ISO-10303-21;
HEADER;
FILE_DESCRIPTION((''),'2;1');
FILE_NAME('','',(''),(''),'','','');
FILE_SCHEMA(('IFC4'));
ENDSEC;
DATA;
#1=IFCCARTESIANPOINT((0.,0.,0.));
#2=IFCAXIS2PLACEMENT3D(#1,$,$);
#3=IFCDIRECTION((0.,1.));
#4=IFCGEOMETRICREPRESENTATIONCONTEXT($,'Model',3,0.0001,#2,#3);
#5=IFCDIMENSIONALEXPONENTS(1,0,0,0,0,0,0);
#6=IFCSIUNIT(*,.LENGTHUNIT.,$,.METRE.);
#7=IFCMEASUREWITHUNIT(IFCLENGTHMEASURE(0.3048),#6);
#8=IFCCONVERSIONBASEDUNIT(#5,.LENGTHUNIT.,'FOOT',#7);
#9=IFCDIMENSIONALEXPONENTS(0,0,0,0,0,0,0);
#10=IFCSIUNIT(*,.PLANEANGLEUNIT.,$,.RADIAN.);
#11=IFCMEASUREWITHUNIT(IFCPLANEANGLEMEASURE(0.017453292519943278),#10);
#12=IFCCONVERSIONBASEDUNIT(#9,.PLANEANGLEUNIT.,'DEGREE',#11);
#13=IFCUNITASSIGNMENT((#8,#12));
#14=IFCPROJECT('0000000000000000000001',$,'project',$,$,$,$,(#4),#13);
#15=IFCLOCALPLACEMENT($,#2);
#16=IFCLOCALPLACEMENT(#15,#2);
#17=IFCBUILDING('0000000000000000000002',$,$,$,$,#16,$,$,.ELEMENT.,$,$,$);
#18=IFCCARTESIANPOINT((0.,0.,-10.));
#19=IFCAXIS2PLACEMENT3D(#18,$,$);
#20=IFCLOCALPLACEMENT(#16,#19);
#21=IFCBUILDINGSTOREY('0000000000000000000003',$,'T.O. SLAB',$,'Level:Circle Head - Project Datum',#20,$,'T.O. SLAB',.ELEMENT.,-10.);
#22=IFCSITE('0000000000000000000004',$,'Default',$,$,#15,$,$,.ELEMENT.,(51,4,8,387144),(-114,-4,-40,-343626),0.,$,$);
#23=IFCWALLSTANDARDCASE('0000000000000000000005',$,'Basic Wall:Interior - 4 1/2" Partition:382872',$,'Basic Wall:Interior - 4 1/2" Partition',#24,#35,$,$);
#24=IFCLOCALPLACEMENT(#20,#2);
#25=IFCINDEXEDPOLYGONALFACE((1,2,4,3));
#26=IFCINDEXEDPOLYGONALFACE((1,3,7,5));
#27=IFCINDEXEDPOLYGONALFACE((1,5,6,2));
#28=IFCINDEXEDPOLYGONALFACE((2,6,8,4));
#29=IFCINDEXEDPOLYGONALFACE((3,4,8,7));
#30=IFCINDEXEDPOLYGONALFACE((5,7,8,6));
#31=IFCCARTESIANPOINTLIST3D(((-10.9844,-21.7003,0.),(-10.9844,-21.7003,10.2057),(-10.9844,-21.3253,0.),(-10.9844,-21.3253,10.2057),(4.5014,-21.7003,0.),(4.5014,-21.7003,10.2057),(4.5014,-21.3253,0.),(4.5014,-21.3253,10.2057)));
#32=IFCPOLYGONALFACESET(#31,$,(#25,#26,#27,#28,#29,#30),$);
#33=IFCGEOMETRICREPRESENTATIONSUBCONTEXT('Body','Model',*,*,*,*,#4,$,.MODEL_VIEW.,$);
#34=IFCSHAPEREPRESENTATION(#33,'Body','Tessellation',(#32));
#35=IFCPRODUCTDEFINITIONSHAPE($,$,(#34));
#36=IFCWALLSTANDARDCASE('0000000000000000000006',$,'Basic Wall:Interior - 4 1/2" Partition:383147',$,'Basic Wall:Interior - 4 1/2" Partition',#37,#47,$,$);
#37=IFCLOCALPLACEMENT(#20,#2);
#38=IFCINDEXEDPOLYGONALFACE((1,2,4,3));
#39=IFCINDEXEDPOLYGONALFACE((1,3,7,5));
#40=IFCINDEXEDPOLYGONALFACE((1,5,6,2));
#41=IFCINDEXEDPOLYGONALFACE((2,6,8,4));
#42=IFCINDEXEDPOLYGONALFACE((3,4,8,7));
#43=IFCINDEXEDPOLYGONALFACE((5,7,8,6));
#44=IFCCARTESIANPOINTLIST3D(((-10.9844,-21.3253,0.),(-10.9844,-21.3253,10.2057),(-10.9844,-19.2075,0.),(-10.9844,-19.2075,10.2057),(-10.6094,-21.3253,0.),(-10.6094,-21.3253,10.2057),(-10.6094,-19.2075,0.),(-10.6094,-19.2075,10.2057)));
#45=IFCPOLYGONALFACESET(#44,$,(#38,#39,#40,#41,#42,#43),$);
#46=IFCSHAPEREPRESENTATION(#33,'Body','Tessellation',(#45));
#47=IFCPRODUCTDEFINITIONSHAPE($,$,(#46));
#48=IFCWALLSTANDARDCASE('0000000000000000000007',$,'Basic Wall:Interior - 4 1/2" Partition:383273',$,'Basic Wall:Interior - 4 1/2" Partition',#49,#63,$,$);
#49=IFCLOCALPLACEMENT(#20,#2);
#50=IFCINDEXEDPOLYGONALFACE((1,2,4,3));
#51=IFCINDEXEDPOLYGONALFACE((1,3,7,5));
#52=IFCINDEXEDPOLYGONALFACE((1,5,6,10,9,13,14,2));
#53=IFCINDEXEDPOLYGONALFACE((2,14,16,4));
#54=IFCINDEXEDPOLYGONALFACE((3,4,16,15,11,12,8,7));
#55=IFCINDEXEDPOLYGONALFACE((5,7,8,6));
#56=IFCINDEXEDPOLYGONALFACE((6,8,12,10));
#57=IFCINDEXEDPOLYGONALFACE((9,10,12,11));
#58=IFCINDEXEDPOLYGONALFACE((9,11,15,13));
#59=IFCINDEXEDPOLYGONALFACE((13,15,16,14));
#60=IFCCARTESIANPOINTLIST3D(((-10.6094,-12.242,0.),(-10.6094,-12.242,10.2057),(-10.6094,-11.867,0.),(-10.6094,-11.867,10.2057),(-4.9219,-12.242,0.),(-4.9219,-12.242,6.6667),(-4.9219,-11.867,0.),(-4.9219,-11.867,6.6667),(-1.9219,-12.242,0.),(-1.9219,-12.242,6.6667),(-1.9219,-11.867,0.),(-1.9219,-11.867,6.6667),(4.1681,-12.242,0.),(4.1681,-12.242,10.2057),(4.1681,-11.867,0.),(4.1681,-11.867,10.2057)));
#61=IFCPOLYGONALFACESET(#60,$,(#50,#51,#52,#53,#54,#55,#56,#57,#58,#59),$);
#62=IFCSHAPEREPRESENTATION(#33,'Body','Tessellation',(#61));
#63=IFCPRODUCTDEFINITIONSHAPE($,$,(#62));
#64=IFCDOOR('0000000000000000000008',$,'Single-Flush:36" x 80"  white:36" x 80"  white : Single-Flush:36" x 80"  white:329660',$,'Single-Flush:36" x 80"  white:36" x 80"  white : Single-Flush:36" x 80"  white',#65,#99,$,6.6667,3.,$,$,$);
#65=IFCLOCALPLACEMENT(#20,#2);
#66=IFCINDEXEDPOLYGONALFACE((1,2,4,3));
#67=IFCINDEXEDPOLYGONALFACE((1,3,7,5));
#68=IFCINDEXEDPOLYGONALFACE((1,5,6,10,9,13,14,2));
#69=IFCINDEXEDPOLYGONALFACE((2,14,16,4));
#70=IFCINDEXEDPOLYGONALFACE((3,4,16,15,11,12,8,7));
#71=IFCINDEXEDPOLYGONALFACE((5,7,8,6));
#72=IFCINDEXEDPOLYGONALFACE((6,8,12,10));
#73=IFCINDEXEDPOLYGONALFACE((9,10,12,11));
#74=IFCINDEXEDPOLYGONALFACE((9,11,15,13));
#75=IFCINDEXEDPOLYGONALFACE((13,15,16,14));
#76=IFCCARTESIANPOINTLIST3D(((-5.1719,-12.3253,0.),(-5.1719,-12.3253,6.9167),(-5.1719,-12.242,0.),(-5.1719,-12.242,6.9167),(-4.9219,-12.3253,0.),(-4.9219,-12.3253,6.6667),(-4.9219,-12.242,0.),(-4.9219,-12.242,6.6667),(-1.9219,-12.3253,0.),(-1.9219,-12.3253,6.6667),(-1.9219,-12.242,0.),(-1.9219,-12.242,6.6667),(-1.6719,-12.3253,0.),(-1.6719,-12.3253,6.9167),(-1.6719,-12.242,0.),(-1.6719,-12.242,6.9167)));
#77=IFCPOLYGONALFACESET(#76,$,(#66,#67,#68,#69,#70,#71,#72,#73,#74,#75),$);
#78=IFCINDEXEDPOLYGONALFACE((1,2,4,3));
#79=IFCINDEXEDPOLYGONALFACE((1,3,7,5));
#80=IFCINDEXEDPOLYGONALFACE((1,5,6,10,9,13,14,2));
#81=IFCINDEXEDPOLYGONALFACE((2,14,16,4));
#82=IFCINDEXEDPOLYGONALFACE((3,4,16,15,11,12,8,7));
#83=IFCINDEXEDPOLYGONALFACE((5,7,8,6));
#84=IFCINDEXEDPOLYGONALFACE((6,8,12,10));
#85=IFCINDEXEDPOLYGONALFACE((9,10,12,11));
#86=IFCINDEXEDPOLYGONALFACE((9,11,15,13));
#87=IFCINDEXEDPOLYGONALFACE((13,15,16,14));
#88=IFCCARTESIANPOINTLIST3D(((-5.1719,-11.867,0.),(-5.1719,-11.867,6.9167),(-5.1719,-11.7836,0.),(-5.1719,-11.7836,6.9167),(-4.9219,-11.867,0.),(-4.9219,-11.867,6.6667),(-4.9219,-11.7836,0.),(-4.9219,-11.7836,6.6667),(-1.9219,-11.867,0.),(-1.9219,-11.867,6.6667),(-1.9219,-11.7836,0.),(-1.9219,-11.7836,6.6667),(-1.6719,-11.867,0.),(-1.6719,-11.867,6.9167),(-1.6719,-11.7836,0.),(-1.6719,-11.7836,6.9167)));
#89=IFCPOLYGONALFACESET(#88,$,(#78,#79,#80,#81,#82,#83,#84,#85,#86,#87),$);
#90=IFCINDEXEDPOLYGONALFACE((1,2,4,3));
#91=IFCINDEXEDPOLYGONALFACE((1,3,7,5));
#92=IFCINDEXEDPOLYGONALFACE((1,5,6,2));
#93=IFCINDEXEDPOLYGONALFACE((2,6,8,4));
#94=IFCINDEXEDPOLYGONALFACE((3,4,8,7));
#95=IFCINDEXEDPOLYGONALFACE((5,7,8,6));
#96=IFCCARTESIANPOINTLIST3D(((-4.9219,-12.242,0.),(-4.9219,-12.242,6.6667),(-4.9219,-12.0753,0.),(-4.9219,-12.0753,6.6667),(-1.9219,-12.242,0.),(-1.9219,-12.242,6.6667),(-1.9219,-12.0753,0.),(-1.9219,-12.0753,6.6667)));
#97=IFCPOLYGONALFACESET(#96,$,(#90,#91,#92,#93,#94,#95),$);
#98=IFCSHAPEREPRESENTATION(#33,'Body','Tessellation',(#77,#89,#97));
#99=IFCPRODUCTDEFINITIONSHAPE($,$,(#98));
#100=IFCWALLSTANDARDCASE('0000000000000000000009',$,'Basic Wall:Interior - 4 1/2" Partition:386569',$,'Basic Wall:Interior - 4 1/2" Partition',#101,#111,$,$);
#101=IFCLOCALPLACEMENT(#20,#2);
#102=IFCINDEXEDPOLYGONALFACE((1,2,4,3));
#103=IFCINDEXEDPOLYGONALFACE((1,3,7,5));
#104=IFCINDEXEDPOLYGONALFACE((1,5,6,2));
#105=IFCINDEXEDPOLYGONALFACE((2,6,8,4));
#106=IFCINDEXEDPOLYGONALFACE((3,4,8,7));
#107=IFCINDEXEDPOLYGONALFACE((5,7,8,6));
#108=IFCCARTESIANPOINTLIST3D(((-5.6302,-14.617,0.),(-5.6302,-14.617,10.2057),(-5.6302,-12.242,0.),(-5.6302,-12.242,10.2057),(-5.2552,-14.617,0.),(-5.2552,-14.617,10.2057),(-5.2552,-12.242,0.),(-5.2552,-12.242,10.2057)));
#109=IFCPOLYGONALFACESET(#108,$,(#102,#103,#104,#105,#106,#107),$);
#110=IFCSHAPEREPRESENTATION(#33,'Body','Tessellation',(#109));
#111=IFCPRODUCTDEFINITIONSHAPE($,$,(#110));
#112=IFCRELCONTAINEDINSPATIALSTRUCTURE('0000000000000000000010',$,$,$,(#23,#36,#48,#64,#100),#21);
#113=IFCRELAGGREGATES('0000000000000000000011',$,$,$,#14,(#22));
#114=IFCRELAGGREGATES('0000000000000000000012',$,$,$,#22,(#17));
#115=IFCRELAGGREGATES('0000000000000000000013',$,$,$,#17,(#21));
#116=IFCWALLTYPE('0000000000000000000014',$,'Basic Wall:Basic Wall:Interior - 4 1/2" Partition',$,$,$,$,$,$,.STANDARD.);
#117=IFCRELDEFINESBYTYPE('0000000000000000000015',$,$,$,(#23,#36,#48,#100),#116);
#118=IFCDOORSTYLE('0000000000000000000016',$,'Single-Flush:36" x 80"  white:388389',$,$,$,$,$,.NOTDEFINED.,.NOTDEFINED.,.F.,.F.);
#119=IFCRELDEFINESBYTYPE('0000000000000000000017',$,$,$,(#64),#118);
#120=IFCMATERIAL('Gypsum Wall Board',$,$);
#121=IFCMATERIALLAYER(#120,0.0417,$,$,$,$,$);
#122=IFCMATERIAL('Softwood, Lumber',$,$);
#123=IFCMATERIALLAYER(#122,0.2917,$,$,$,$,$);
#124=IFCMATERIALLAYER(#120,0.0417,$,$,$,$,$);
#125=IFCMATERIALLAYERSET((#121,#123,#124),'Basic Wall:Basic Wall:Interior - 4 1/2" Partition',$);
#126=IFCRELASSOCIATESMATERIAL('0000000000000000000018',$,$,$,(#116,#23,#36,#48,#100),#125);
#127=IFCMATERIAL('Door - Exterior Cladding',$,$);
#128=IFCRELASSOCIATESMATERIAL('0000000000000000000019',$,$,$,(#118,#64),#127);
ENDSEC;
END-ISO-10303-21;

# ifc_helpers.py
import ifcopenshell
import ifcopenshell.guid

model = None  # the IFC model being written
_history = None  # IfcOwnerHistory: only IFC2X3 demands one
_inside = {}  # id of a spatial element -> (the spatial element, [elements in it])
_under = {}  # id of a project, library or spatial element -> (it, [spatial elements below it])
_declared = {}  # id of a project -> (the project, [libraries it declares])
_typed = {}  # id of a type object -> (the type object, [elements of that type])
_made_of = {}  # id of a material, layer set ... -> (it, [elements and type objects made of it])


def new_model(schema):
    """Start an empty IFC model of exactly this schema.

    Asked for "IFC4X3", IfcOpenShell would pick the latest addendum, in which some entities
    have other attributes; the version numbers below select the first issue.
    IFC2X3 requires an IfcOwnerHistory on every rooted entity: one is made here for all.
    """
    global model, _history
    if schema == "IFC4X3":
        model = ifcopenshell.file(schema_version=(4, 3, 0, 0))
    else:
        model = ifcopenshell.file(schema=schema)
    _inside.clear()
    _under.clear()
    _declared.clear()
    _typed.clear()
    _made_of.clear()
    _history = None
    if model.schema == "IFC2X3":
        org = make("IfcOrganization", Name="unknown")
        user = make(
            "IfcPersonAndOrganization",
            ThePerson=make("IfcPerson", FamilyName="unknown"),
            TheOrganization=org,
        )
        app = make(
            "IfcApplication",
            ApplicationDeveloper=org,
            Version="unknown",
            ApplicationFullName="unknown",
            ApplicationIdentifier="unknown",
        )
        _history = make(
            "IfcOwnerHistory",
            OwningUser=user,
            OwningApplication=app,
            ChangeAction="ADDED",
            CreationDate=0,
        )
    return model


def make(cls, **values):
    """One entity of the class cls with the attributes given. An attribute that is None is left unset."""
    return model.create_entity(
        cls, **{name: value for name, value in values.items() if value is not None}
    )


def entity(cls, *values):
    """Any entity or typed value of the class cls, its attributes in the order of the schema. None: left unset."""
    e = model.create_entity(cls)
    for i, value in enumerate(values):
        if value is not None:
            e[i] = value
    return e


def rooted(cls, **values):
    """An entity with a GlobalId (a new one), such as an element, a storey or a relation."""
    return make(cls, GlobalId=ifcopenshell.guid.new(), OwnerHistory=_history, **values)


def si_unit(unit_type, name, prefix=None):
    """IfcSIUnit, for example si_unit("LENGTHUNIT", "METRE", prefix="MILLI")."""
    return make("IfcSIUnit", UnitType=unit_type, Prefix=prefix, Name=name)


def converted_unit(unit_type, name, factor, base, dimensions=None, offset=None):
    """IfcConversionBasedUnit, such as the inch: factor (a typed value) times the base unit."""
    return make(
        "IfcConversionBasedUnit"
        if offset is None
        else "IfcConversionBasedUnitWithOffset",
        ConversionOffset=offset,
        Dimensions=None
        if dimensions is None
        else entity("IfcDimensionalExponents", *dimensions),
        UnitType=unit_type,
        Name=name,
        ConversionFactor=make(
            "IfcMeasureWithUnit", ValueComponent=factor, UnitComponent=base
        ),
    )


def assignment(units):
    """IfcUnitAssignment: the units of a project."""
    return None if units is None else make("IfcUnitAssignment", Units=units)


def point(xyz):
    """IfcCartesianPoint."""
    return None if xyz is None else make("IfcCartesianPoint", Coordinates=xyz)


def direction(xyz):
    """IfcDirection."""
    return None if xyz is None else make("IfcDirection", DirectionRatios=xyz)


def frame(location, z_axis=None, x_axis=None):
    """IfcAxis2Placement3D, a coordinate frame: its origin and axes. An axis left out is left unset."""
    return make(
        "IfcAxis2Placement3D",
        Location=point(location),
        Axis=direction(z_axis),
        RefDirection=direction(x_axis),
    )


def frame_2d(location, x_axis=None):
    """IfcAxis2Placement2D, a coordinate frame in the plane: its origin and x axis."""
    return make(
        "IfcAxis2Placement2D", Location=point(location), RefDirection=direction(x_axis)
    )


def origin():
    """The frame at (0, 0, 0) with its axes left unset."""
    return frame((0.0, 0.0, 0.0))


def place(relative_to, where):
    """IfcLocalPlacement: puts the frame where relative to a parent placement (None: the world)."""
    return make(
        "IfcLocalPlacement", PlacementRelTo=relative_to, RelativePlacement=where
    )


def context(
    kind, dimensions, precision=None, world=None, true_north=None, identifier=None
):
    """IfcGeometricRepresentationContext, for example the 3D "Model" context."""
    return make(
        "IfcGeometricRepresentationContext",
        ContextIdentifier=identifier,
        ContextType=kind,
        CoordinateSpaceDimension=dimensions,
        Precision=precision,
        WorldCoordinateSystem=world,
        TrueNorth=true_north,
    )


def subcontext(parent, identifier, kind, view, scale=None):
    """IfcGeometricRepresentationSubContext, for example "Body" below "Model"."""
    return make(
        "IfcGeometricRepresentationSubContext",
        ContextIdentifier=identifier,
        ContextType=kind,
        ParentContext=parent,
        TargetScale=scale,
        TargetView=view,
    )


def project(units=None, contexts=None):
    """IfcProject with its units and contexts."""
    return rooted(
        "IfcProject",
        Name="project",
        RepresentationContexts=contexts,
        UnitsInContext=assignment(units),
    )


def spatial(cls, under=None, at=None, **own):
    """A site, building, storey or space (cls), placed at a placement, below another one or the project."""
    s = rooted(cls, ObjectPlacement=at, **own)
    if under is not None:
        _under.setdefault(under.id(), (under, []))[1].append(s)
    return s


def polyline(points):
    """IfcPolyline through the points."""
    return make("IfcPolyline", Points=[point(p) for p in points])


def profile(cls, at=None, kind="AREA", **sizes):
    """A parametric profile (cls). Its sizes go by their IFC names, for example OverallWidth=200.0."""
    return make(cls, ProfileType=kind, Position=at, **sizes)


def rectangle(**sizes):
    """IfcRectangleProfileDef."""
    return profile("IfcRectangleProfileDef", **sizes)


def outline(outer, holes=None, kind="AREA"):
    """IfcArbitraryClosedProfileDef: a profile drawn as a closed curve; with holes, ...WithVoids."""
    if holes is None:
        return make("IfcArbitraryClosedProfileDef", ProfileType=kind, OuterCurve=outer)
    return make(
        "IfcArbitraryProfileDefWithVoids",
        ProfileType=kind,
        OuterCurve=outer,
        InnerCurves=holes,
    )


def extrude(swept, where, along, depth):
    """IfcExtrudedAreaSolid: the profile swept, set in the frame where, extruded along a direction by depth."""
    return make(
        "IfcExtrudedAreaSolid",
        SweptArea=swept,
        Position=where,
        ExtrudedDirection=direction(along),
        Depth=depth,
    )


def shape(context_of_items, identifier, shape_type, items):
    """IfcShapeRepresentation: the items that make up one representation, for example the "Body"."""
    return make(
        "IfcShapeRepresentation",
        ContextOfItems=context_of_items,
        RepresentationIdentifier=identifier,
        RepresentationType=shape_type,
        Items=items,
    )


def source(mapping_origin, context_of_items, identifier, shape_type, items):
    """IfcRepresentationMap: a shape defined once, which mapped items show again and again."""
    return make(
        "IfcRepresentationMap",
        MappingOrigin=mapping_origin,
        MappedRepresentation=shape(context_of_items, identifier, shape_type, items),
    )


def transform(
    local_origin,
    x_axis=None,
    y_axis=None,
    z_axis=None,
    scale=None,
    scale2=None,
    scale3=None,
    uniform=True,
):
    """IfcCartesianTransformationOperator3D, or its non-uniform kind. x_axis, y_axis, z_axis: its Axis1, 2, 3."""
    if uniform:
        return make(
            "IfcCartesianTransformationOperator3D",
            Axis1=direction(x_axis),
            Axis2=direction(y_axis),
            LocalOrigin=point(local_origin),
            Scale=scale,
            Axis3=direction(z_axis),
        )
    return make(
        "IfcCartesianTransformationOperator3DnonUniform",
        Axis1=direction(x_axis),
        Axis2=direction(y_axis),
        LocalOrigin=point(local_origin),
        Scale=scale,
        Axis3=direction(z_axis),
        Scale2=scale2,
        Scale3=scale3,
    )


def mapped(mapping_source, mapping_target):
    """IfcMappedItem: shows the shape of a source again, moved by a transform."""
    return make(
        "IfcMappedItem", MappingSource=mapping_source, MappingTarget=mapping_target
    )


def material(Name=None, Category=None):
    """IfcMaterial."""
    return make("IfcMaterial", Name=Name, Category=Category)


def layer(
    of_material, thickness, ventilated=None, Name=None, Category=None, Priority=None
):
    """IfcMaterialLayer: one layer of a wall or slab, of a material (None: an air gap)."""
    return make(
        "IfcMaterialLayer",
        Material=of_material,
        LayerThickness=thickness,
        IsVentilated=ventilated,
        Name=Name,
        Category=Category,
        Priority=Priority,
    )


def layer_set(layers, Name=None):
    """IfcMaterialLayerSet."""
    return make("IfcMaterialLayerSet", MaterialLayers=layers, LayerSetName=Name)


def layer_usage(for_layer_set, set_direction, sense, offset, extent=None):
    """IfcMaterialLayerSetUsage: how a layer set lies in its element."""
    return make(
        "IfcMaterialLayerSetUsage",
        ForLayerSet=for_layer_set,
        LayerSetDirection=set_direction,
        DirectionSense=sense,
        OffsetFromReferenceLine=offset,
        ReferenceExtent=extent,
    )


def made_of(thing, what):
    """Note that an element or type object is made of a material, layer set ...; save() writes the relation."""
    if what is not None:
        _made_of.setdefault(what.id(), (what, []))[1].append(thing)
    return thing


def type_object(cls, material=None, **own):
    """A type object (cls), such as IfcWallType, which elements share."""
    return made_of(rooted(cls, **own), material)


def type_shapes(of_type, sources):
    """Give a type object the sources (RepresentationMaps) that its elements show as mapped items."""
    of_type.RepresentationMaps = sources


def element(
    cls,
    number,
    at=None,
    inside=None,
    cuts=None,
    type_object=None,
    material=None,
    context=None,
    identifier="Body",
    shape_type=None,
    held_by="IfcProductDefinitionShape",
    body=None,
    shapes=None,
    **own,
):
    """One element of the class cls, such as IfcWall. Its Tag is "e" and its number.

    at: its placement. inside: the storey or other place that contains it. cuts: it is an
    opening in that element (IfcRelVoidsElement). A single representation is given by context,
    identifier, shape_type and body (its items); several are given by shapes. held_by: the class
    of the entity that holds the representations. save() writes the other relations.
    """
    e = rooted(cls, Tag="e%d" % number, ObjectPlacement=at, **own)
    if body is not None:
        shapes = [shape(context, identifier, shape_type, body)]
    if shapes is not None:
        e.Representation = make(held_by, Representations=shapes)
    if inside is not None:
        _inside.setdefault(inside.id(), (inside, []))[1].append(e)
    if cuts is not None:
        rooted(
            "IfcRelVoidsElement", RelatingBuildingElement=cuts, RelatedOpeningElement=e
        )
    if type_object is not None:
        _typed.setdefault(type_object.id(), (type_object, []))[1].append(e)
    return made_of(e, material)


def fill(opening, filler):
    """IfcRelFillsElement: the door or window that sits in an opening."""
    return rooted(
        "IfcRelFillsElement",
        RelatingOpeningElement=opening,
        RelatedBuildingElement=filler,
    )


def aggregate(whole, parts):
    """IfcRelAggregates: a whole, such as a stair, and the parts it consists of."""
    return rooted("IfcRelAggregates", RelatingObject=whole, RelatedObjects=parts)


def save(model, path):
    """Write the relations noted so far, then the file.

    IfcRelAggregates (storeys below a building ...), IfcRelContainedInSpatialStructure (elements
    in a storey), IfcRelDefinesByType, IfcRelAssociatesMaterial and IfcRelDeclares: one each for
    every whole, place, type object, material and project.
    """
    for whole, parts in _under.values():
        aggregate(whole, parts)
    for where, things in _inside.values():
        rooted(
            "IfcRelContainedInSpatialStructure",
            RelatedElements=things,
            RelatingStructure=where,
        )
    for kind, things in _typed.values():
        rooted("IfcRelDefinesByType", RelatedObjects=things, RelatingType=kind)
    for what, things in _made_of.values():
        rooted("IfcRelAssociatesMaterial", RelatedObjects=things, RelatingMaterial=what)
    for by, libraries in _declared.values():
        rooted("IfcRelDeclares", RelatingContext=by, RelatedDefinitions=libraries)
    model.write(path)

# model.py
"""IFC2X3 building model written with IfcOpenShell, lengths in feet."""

from ifc_helpers import new_model, entity, si_unit, converted_unit, direction, frame, frame_2d, origin, place, context, subcontext, project, spatial, polyline, rectangle, outline, extrude, source, transform, mapped, material, layer, layer_set, layer_usage, type_object, type_shapes, element, fill, save


model = new_model("IFC2X3")

# Units and contexts
model_context = context("Model", 3, precision=0.0001, world=origin(), true_north=direction((0.0, 1.0)))
body_context = subcontext(model_context, "Body", "Model", "MODEL_VIEW")
ifc_project = project(units=[converted_unit("LENGTHUNIT", "FOOT", entity("IfcLengthMeasure", 0.3048), si_unit("LENGTHUNIT", "METRE"), dimensions=[1, 0, 0, 0, 0, 0, 0]), converted_unit("PLANEANGLEUNIT", "DEGREE", entity("IfcPlaneAngleMeasure", 0.017453292519943278), si_unit("PLANEANGLEUNIT", "RADIAN"), dimensions=[0, 0, 0, 0, 0, 0, 0])], contexts=[model_context])

# Site, building, storey
site_placement = place(None, origin())
site = spatial("IfcSite", under=ifc_project, at=site_placement, Name="Default", CompositionType="ELEMENT", RefLatitude=(51, 4, 8, 387144), RefLongitude=(-114, -4, -40, -343626), RefElevation=0.0)
building_placement = place(site_placement, origin())
building = spatial("IfcBuilding", under=site, at=building_placement, CompositionType="ELEMENT")
storey_placement = place(building_placement, frame((0.0, 0.0, -10.0)))
storey = spatial("IfcBuildingStorey", under=building, at=storey_placement, Name="T.O. SLAB", ObjectType="Level:Circle Head - Project Datum", LongName="T.O. SLAB", CompositionType="ELEMENT", Elevation=-10.0)

# Walls
ifc_material_1 = material(Name="Gypsum Wall Board")
ifc_layer_1 = layer(ifc_material_1, 0.0417)
ifc_material_2 = material(Name="Softwood, Lumber")
ifc_layer_2 = layer(ifc_material_2, 0.2917)
ifc_layer_3 = layer(ifc_material_1, 0.0417)
ifc_layer_set_1 = layer_set([ifc_layer_1, ifc_layer_2, ifc_layer_3], Name="Basic Wall:Basic Wall:Interior - 4 1/2\" Partition")
ifc_layer_usage_1 = layer_usage(ifc_layer_set_1, "AXIS2", "NEGATIVE", 0.1875)
wall_type_1 = type_object("IfcWallType", Name="Basic Wall:Basic Wall:Interior - 4 1/2\" Partition", PredefinedType="STANDARD", material=ifc_layer_set_1)
wall_1_placement = place(storey_placement, frame((4.5014, -21.5128, 0.0), z_axis=(0.0, 0.0, 1.0), x_axis=(-1.0, 0.0, 0.0)))
element("IfcWallStandardCase", 1, at=wall_1_placement, inside=storey, type_object=wall_type_1, material=ifc_layer_usage_1, Name="Basic Wall:Interior - 4 1/2\" Partition:382872", ObjectType="Basic Wall:Interior - 4 1/2\" Partition", context=body_context, shape_type="SweptSolid", body=[
    extrude(rectangle(XDim=15.4858, YDim=0.375, at=frame_2d((7.7429, 0.0), x_axis=(-1.0, 0.0))), origin(), (0.0, 0.0, 1.0), 10.2057),
])
ifc_layer_usage_2 = layer_usage(ifc_layer_set_1, "AXIS2", "NEGATIVE", 0.1875)
wall_2_placement = place(storey_placement, frame((-10.7969, -21.3253, 0.0), z_axis=(0.0, 0.0, 1.0), x_axis=(0.0, 1.0, 0.0)))
element("IfcWallStandardCase", 2, at=wall_2_placement, inside=storey, type_object=wall_type_1, material=ifc_layer_usage_2, Name="Basic Wall:Interior - 4 1/2\" Partition:383147", ObjectType="Basic Wall:Interior - 4 1/2\" Partition", context=body_context, shape_type="SweptSolid", body=[
    extrude(rectangle(XDim=2.1178, YDim=0.375, at=frame_2d((1.0589, 0.0), x_axis=(-1.0, 0.0))), origin(), (0.0, 0.0, 1.0), 10.2057),
])

# Wall, opening, door
ifc_layer_usage_3 = layer_usage(ifc_layer_set_1, "AXIS2", "NEGATIVE", 0.1875)
wall_3_placement = place(storey_placement, frame((4.1681, -12.0545, 0.0), z_axis=(0.0, 0.0, 1.0), x_axis=(-1.0, 0.0, 0.0)))
wall_3 = element("IfcWallStandardCase", 3, at=wall_3_placement, inside=storey, type_object=wall_type_1, material=ifc_layer_usage_3, Name="Basic Wall:Interior - 4 1/2\" Partition:383273", ObjectType="Basic Wall:Interior - 4 1/2\" Partition", context=body_context, shape_type="SweptSolid", body=[
    extrude(rectangle(XDim=14.7775, YDim=0.375, at=frame_2d((7.3887, 0.0), x_axis=(1.0, 0.0))), origin(), (0.0, 0.0, 1.0), 10.2057),
])
opening_1_placement = place(wall_3_placement, frame((4.1681, -12.0545, 0.0), z_axis=(0.0, 0.0, 1.0), x_axis=(-1.0, 0.0, 0.0)))
opening_1 = element("IfcOpeningElement", 4, at=opening_1_placement, cuts=wall_3, ObjectType="Opening", context=body_context, shape_type="SweptSolid", body=[
    extrude(rectangle(XDim=6.6667, YDim=3.0, at=frame_2d((0.0, 0.0), x_axis=(1.0, 0.0))), frame((-3.4219, -11.8632, 3.3333), z_axis=(0.0, -1.0, 0.0), x_axis=(0.0, 0.0, -1.0)), (0.0, 0.0, 1.0), 0.3825),
])
ifc_material_3 = material(Name="Door - Exterior Cladding")
door_style_1 = type_object("IfcDoorStyle", Name="Single-Flush:36\" x 80\"  white:388389", ConstructionType="NOTDEFINED", OperationType="NOTDEFINED", ParameterTakesPrecedence=False, Sizeable=False, material=ifc_material_3)
shared_shape_1 = source(origin(), body_context, "Body", "SweptSolid", [
    extrude(outline(polyline([(-3.5208, -1.75), (3.3958, -1.75), (3.3958, -1.5), (-3.2708, -1.5), (-3.2708, 1.5), (3.3958, 1.5), (3.3958, 1.75), (-3.5208, 1.75), (-3.5208, -1.75)])), frame((1.5, -0.0038, 3.3958), z_axis=(0.0, 1.0, 0.0), x_axis=(0.0, 0.0, -1.0)), (0.0, 0.0, 1.0), 0.0833),
    extrude(outline(polyline([(-1.75, -3.3958), (-1.5, -3.3958), (-1.5, 3.2708), (1.5, 3.2708), (1.5, -3.3958), (1.75, -3.3958), (1.75, 3.5208), (-1.75, 3.5208), (-1.75, -3.3958)])), frame((1.5, -0.4621, 3.3958), z_axis=(0.0, 1.0, 0.0), x_axis=(-1.0, 0.0, 0.0)), (0.0, 0.0, 1.0), 0.0833),
    extrude(rectangle(XDim=3.0, YDim=0.1667, at=frame_2d((0.0, 0.0), x_axis=(1.0, 0.0))), frame((1.5, -0.0871, 0.0), z_axis=(0.0, 0.0, 1.0), x_axis=(-1.0, 0.0, 0.0)), (0.0, 0.0, 1.0), 6.6667),
])
type_shapes(door_style_1, [shared_shape_1])
door_1_placement = place(opening_1_placement, frame((-1.9219, -12.2457, 0.0), z_axis=(0.0, 0.0, 1.0), x_axis=(-1.0, 0.0, 0.0)))
door_1 = element("IfcDoor", 5, at=door_1_placement, inside=storey, type_object=door_style_1, material=ifc_material_3, Name="Single-Flush:36\" x 80\"  white:36\" x 80\"  white : Single-Flush:36\" x 80\"  white:329660", ObjectType="Single-Flush:36\" x 80\"  white:36\" x 80\"  white : Single-Flush:36\" x 80\"  white", OverallHeight=6.6667, OverallWidth=3.0, context=body_context, shape_type="MappedRepresentation", body=[
    mapped(shared_shape_1, transform((0.0, 0.0, 0.0), scale=1.0)),
])
fill(opening_1, door_1)

# Wall
ifc_layer_usage_4 = layer_usage(ifc_layer_set_1, "AXIS2", "NEGATIVE", 0.1875)
wall_4_placement = place(storey_placement, frame((-5.4427, -12.242, 0.0), z_axis=(0.0, 0.0, 1.0), x_axis=(0.0, -1.0, 0.0)))
element("IfcWallStandardCase", 6, at=wall_4_placement, inside=storey, type_object=wall_type_1, material=ifc_layer_usage_4, Name="Basic Wall:Interior - 4 1/2\" Partition:386569", ObjectType="Basic Wall:Interior - 4 1/2\" Partition", context=body_context, shape_type="SweptSolid", body=[
    extrude(rectangle(XDim=2.375, YDim=0.375, at=frame_2d((1.1875, 0.0), x_axis=(-1.0, 0.0))), origin(), (0.0, 0.0, 1.0), 10.2057),
])

save(model, "model.ifc")
